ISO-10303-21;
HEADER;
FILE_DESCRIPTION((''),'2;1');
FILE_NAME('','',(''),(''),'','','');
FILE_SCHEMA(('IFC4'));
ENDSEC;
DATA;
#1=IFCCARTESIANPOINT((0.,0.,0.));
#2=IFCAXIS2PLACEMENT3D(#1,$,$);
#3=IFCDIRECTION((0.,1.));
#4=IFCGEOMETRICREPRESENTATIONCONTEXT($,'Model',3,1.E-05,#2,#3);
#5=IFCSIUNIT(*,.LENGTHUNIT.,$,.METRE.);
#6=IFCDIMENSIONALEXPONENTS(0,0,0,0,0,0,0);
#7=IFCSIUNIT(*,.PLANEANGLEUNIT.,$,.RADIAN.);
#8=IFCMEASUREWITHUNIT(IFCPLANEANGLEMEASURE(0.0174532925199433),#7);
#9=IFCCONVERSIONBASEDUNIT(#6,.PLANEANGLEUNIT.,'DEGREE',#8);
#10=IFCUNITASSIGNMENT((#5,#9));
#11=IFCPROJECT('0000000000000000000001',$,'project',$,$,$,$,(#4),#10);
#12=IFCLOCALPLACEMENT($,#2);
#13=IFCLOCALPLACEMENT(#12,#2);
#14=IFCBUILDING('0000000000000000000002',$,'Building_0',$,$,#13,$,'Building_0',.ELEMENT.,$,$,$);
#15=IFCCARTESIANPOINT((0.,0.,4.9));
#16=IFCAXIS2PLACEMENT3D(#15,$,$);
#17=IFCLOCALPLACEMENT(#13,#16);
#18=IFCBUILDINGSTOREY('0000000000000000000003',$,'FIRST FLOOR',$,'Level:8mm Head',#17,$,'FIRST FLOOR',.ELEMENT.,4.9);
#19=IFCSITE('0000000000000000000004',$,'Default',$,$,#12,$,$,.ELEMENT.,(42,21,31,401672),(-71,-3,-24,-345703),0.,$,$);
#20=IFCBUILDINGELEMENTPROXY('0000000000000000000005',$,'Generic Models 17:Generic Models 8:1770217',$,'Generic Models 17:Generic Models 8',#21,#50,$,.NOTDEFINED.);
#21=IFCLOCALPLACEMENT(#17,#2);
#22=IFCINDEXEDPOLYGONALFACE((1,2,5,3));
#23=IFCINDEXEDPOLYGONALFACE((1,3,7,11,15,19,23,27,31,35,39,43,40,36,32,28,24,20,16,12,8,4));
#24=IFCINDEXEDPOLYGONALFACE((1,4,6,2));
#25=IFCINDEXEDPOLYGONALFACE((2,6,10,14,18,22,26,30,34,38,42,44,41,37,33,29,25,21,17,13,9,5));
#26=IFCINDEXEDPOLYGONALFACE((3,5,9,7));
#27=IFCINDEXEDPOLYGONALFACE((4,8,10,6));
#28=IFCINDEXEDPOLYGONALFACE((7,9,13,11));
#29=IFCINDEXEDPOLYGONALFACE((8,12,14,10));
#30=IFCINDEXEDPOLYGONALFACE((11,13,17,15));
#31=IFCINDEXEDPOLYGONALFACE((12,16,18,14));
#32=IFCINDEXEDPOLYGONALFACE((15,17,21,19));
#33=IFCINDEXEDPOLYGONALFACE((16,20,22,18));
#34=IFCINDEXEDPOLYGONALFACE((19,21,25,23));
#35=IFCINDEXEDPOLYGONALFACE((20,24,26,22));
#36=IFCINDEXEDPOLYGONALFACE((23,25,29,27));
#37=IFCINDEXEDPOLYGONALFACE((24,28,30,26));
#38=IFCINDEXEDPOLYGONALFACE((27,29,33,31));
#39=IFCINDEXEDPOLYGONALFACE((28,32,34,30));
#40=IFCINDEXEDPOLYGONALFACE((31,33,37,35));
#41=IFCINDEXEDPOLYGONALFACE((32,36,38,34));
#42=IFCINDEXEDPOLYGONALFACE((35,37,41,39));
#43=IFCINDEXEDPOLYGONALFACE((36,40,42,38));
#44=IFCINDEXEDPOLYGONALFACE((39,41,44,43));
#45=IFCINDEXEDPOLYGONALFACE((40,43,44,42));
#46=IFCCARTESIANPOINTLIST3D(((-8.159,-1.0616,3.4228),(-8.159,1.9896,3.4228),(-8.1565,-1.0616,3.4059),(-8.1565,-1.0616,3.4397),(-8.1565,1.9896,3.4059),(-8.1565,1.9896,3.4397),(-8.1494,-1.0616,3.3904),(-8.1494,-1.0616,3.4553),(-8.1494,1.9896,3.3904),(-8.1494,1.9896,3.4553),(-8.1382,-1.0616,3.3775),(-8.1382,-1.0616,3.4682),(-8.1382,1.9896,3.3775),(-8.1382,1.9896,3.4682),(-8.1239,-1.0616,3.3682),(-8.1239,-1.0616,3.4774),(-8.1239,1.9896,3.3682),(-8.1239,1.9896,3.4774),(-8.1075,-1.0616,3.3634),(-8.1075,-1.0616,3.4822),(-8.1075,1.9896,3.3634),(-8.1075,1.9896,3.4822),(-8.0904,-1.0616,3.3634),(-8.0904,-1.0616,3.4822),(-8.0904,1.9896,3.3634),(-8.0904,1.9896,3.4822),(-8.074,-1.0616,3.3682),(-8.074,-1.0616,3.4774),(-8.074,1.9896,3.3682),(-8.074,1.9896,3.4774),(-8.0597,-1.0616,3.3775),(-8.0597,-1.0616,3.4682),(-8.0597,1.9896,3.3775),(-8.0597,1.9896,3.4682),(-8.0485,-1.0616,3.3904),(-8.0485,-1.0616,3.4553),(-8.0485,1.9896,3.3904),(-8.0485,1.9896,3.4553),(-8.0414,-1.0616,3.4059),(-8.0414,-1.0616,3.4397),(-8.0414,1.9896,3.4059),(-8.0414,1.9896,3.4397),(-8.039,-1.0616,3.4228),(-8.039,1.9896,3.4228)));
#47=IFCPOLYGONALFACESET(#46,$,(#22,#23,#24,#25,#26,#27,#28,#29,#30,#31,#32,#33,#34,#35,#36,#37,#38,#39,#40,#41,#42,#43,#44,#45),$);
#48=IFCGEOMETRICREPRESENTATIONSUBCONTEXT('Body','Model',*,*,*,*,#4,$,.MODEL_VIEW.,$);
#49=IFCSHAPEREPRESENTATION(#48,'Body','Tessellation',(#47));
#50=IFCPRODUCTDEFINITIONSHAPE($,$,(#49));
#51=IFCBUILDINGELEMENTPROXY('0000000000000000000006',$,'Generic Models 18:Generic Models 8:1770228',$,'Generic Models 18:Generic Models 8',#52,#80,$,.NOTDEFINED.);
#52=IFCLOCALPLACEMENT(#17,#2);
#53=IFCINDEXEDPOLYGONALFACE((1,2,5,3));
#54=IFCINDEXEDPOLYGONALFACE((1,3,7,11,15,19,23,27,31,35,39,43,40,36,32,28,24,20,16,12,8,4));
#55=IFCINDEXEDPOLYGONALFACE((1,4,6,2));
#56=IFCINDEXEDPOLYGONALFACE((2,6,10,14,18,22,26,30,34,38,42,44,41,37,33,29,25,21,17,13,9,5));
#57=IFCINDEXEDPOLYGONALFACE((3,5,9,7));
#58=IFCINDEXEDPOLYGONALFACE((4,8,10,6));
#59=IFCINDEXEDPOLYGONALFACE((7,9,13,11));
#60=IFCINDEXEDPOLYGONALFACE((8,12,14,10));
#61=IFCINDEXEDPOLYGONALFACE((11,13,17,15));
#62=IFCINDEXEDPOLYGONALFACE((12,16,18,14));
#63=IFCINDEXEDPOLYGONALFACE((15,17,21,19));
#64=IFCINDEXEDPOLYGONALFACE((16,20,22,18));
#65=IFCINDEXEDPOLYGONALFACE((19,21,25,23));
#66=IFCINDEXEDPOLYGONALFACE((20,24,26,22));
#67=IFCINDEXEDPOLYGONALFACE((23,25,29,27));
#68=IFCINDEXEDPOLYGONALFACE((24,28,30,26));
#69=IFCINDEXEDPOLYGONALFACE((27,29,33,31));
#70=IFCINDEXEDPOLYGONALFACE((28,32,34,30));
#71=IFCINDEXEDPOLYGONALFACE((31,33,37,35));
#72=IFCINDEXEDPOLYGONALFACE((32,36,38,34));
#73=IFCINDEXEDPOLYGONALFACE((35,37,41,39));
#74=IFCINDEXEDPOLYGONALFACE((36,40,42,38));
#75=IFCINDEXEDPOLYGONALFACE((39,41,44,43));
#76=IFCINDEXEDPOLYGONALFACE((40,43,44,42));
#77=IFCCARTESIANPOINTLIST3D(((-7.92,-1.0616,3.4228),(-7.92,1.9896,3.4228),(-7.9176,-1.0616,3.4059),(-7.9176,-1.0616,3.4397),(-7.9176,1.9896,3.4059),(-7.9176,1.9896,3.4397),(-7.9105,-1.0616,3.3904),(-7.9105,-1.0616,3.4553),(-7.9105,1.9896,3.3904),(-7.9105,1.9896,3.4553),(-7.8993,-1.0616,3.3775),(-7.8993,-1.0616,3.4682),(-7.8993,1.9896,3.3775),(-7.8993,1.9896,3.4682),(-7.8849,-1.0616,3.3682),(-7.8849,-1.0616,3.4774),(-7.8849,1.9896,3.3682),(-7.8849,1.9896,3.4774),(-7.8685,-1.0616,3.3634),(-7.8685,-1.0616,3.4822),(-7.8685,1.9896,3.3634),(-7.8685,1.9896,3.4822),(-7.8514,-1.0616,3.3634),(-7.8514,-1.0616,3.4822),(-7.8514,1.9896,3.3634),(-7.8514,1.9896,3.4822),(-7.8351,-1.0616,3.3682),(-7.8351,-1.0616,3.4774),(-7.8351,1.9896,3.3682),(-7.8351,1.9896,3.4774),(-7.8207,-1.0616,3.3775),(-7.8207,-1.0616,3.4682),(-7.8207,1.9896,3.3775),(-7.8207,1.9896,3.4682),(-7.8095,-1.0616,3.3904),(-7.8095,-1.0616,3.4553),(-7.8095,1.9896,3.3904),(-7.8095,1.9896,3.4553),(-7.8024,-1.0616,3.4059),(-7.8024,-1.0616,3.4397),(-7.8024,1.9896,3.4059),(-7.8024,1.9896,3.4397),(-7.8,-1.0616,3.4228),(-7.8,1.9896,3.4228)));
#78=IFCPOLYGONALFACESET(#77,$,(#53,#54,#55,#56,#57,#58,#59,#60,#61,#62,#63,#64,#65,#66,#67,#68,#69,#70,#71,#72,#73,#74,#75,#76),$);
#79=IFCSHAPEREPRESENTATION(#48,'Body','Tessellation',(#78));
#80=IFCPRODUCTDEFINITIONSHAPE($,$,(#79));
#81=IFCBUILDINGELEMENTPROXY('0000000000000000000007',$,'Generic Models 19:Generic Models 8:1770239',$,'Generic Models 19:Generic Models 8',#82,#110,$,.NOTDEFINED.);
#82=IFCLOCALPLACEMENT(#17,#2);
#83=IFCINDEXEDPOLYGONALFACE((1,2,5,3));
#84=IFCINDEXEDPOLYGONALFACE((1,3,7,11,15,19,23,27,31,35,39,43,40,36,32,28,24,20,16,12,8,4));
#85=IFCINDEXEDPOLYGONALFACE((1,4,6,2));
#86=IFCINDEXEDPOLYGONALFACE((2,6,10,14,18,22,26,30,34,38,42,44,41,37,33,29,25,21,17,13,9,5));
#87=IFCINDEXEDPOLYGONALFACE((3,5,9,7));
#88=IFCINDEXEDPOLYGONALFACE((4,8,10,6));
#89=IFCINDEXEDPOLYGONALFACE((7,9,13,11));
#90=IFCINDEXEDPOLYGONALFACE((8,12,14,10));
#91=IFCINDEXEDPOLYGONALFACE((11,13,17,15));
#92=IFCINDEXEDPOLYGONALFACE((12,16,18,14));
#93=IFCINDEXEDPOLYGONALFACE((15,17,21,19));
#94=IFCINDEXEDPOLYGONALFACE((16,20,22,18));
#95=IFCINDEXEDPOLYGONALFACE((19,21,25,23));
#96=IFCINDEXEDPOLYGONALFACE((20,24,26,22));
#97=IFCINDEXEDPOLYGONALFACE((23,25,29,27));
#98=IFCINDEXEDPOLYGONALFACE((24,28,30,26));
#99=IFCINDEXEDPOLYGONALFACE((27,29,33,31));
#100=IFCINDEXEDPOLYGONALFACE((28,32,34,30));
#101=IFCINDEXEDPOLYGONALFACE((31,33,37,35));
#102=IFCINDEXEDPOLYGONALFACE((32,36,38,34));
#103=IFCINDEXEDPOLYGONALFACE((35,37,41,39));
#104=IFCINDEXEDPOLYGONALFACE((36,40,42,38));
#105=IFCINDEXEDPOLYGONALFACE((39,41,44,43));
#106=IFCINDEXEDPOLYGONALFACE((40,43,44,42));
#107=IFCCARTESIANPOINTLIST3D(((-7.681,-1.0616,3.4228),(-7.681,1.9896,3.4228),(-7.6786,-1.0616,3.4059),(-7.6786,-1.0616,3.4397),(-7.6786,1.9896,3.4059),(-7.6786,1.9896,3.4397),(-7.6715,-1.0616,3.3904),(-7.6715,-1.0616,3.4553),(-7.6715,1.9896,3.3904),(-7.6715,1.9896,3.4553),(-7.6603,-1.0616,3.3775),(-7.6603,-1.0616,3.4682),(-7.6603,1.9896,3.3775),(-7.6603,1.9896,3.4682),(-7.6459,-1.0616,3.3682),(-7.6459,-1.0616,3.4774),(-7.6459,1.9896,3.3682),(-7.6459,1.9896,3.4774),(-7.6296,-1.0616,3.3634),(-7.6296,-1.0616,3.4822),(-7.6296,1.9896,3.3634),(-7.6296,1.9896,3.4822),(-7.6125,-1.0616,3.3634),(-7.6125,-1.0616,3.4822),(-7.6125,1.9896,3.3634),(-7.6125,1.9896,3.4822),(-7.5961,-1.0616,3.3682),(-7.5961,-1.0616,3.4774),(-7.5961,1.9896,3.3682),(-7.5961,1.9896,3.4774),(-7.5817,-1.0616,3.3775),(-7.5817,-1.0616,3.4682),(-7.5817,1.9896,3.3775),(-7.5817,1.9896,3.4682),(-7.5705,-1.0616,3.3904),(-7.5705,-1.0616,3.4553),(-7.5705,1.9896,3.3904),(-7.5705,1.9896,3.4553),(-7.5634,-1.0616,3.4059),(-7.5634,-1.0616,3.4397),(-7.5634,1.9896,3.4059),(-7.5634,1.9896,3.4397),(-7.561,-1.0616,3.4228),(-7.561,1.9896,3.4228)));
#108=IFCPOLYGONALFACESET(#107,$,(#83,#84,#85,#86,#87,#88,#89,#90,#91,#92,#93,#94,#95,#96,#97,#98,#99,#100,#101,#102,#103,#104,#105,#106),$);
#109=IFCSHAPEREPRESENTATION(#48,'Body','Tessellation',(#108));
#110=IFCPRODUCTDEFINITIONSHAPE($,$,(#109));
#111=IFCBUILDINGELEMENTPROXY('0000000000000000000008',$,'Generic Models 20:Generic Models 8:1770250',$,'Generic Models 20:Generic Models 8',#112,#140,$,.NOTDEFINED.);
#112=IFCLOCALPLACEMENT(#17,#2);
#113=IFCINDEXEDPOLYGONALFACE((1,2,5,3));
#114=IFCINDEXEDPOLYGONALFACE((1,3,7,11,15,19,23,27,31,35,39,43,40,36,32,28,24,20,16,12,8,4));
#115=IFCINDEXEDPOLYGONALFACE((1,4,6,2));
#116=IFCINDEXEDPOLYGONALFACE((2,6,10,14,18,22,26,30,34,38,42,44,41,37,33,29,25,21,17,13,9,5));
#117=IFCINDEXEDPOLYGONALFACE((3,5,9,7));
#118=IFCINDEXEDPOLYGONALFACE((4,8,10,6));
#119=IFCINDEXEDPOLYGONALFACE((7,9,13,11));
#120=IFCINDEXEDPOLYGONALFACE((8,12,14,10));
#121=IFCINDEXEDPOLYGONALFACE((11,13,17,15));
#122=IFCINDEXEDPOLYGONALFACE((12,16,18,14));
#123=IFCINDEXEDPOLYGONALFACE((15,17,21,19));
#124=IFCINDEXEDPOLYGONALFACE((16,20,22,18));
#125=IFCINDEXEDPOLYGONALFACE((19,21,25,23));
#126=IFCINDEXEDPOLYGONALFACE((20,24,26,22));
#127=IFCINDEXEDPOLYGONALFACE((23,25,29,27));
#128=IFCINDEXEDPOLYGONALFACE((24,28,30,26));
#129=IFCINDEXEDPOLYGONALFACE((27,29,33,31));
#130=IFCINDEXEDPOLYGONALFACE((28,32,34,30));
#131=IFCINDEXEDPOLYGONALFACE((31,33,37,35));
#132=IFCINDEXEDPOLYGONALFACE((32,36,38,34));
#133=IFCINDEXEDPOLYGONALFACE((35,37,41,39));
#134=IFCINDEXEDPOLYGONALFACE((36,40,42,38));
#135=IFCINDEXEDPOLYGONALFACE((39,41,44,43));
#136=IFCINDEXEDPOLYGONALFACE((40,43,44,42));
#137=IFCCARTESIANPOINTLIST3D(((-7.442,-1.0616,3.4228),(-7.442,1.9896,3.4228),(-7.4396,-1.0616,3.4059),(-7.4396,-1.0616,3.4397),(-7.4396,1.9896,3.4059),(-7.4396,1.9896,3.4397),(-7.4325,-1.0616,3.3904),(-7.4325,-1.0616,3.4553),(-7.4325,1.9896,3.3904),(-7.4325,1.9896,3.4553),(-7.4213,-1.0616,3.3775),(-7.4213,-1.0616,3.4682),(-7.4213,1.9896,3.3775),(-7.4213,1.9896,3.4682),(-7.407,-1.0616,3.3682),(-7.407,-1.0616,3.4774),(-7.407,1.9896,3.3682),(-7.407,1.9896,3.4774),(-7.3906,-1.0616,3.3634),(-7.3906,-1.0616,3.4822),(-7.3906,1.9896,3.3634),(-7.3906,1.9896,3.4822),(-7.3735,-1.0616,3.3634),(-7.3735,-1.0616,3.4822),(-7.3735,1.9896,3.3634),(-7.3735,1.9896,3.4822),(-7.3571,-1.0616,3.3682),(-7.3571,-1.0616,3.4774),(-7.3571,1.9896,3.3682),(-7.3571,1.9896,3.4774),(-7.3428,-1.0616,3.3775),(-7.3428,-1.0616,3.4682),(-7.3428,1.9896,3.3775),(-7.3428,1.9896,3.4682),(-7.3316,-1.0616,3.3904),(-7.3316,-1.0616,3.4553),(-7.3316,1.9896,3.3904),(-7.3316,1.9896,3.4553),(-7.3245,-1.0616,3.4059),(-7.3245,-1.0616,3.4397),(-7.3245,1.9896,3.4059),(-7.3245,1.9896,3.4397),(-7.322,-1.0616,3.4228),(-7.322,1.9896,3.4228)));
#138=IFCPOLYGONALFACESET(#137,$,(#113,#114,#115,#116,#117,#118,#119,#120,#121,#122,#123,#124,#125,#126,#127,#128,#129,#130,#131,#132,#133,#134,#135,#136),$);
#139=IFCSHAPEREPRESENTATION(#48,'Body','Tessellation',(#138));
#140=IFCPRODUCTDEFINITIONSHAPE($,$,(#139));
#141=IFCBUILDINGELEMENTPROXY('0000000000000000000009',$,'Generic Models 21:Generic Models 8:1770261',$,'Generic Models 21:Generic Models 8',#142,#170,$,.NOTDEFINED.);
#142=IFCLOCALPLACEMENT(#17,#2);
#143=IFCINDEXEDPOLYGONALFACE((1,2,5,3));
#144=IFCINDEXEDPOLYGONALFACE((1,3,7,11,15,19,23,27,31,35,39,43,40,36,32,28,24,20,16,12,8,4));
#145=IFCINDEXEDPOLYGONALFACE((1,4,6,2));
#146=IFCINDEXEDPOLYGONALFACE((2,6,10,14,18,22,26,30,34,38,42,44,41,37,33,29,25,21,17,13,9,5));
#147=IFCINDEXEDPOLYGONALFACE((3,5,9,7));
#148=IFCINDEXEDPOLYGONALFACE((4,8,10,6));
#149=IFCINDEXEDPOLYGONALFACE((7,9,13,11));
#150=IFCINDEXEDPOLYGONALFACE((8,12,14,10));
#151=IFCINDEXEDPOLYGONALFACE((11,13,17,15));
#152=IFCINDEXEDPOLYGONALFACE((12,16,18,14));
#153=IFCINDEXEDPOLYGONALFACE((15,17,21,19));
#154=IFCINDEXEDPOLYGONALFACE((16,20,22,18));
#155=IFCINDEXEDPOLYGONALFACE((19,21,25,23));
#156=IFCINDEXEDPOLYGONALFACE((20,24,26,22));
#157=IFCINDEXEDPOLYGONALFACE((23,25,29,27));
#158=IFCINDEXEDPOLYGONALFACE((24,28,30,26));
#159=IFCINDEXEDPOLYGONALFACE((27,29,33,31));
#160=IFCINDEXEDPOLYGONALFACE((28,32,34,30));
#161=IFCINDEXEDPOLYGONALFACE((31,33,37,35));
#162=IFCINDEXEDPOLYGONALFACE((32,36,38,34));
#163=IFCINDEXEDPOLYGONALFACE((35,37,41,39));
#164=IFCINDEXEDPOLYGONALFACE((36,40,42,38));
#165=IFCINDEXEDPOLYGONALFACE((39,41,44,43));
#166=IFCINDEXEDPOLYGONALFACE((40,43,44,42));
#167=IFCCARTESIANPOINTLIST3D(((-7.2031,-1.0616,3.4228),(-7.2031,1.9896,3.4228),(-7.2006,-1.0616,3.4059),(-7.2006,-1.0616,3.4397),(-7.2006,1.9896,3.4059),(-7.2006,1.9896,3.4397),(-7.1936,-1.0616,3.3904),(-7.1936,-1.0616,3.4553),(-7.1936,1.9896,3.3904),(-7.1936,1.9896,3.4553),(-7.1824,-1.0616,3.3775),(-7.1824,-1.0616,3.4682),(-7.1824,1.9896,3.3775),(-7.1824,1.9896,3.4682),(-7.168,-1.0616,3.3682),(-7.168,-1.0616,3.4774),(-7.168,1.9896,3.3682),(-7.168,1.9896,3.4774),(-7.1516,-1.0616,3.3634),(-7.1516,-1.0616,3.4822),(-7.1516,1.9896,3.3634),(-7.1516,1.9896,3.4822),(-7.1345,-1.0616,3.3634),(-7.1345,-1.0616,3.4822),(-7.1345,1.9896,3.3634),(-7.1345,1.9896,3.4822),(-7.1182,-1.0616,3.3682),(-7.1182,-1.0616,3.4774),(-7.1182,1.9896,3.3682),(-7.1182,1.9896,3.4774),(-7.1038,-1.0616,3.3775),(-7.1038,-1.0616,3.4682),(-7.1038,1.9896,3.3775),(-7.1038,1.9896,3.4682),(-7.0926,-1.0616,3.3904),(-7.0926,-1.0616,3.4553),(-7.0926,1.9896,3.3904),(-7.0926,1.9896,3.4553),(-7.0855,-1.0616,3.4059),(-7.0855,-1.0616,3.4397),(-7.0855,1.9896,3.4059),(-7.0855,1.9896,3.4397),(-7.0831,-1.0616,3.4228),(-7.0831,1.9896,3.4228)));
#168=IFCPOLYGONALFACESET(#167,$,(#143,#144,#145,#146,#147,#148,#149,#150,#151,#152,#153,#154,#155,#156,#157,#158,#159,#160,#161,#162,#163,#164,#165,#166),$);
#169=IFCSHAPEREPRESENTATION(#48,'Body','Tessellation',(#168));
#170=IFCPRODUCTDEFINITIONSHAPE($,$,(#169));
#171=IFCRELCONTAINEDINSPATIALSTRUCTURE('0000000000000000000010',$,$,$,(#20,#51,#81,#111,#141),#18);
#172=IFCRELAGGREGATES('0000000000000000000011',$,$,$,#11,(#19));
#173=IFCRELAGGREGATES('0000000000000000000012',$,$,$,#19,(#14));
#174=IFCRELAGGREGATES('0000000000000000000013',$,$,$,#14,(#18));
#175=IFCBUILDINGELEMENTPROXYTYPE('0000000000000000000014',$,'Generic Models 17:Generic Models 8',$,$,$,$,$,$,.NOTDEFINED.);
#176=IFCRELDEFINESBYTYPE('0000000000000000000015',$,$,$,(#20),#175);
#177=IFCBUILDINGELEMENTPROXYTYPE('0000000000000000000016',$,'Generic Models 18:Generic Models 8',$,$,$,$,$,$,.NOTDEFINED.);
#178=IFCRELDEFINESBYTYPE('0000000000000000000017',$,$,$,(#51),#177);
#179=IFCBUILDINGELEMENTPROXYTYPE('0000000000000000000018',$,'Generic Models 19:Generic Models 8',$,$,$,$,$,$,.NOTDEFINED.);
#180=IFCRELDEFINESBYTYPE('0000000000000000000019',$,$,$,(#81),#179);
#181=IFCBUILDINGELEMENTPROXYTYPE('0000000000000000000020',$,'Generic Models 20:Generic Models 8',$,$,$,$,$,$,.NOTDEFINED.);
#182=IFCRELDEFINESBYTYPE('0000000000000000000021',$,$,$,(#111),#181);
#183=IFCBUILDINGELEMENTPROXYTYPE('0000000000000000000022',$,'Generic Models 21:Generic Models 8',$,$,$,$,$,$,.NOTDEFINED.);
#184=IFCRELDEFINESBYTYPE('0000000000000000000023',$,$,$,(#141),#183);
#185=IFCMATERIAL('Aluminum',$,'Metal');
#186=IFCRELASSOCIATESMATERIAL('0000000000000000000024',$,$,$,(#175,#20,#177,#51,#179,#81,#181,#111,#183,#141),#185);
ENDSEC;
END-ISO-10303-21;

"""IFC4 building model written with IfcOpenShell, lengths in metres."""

from ifc_helpers import new_model, entity, si_unit, converted_unit, direction, frame, origin, place, context, subcontext, project, spatial, arc, indexed_curve, outline, extrude, source, transform, mapped, material, type_object, type_shapes, element, save


model = new_model("IFC4")

# Units and contexts
model_context = context("Model", 3, precision=1e-05, world=origin(), true_north=direction((0.0, 1.0)))
body_context = subcontext(model_context, "Body", "Model", "MODEL_VIEW")
ifc_project = project(units=[si_unit("LENGTHUNIT", "METRE"), converted_unit("PLANEANGLEUNIT", "DEGREE", entity("IfcPlaneAngleMeasure", 0.0174532925199433), si_unit("PLANEANGLEUNIT", "RADIAN"), dimensions=[0, 0, 0, 0, 0, 0, 0])], contexts=[model_context])

# Site, building, storey
site_placement = place(None, origin())
site = spatial("IfcSite", under=ifc_project, at=site_placement, Name="Default", CompositionType="ELEMENT", RefLatitude=(42, 21, 31, 401672), RefLongitude=(-71, -3, -24, -345703), RefElevation=0.0)
building_placement = place(site_placement, origin())
building = spatial("IfcBuilding", under=site, at=building_placement, Name="Building_0", LongName="Building_0", CompositionType="ELEMENT")
storey_placement = place(building_placement, frame((0.0, 0.0, 4.9)))
storey = spatial("IfcBuildingStorey", under=building, at=storey_placement, Name="FIRST FLOOR", ObjectType="Level:8mm Head", LongName="FIRST FLOOR", CompositionType="ELEMENT", Elevation=4.9)

# Building element proxies
ifc_material = material(Name="Aluminum", Category="Metal")
building_element_proxy_type_1 = type_object("IfcBuildingElementProxyType", Name="Generic Models 17:Generic Models 8", PredefinedType="NOTDEFINED", material=ifc_material)
shared_shape_1 = source(origin(), body_context, "Body", "SweptSolid", [
    extrude(outline(indexed_curve([(-0.06, 0.0), (0.0, -0.06), (0.06, 0.0), (0.0, 0.06)], segments=[arc(1, 2, 3), arc(3, 4, 1)], self_intersect=False)), frame((-8.099, -1.0616, 8.3228), z_axis=(0.0, 1.0, 0.0), x_axis=(-1.0, 0.0, 0.0)), (0.0, 0.0, 1.0), 3.0512),
])
type_shapes(building_element_proxy_type_1, [shared_shape_1])
proxy_1_placement = place(storey_placement, frame((0.0, 0.0, -4.9)))
element("IfcBuildingElementProxy", 1, at=proxy_1_placement, inside=storey, type_object=building_element_proxy_type_1, material=ifc_material, Name="Generic Models 17:Generic Models 8:1770217", ObjectType="Generic Models 17:Generic Models 8", PredefinedType="NOTDEFINED", context=body_context, shape_type="MappedRepresentation", body=[
    mapped(shared_shape_1, transform((0.0, 0.0, 0.0), scale=1.0)),
])
building_element_proxy_type_2 = type_object("IfcBuildingElementProxyType", Name="Generic Models 18:Generic Models 8", PredefinedType="NOTDEFINED", material=ifc_material)
shared_shape_2 = source(origin(), body_context, "Body", "SweptSolid", [
    extrude(outline(indexed_curve([(-0.06, 0.0), (0.0, -0.06), (0.06, 0.0), (0.0, 0.06)], segments=[arc(1, 2, 3), arc(3, 4, 1)], self_intersect=False)), frame((-7.86, -1.0616, 8.3228), z_axis=(0.0, 1.0, 0.0), x_axis=(-1.0, 0.0, 0.0)), (0.0, 0.0, 1.0), 3.0512),
])
type_shapes(building_element_proxy_type_2, [shared_shape_2])
proxy_2_placement = place(storey_placement, frame((0.0, 0.0, -4.9)))
element("IfcBuildingElementProxy", 2, at=proxy_2_placement, inside=storey, type_object=building_element_proxy_type_2, material=ifc_material, Name="Generic Models 18:Generic Models 8:1770228", ObjectType="Generic Models 18:Generic Models 8", PredefinedType="NOTDEFINED", context=body_context, shape_type="MappedRepresentation", body=[
    mapped(shared_shape_2, transform((0.0, 0.0, 0.0), scale=1.0)),
])
building_element_proxy_type_3 = type_object("IfcBuildingElementProxyType", Name="Generic Models 19:Generic Models 8", PredefinedType="NOTDEFINED", material=ifc_material)
shared_shape_3 = source(origin(), body_context, "Body", "SweptSolid", [
    extrude(outline(indexed_curve([(-0.06, 0.0), (0.0, -0.06), (0.06, 0.0), (0.0, 0.06)], segments=[arc(1, 2, 3), arc(3, 4, 1)], self_intersect=False)), frame((-7.621, -1.0616, 8.3228), z_axis=(0.0, 1.0, 0.0), x_axis=(-1.0, 0.0, 0.0)), (0.0, 0.0, 1.0), 3.0512),
])
type_shapes(building_element_proxy_type_3, [shared_shape_3])
proxy_3_placement = place(storey_placement, frame((0.0, 0.0, -4.9)))
element("IfcBuildingElementProxy", 3, at=proxy_3_placement, inside=storey, type_object=building_element_proxy_type_3, material=ifc_material, Name="Generic Models 19:Generic Models 8:1770239", ObjectType="Generic Models 19:Generic Models 8", PredefinedType="NOTDEFINED", context=body_context, shape_type="MappedRepresentation", body=[
    mapped(shared_shape_3, transform((0.0, 0.0, 0.0), scale=1.0)),
])
building_element_proxy_type_4 = type_object("IfcBuildingElementProxyType", Name="Generic Models 20:Generic Models 8", PredefinedType="NOTDEFINED", material=ifc_material)
shared_shape_4 = source(origin(), body_context, "Body", "SweptSolid", [
    extrude(outline(indexed_curve([(-0.06, 0.0), (0.0, -0.06), (0.06, 0.0), (0.0, 0.06)], segments=[arc(1, 2, 3), arc(3, 4, 1)], self_intersect=False)), frame((-7.382, -1.0616, 8.3228), z_axis=(0.0, 1.0, 0.0), x_axis=(-1.0, 0.0, 0.0)), (0.0, 0.0, 1.0), 3.0512),
])
type_shapes(building_element_proxy_type_4, [shared_shape_4])
proxy_4_placement = place(storey_placement, frame((0.0, 0.0, -4.9)))
element("IfcBuildingElementProxy", 4, at=proxy_4_placement, inside=storey, type_object=building_element_proxy_type_4, material=ifc_material, Name="Generic Models 20:Generic Models 8:1770250", ObjectType="Generic Models 20:Generic Models 8", PredefinedType="NOTDEFINED", context=body_context, shape_type="MappedRepresentation", body=[
    mapped(shared_shape_4, transform((0.0, 0.0, 0.0), scale=1.0)),
])
building_element_proxy_type_5 = type_object("IfcBuildingElementProxyType", Name="Generic Models 21:Generic Models 8", PredefinedType="NOTDEFINED", material=ifc_material)
shared_shape_5 = source(origin(), body_context, "Body", "SweptSolid", [
    extrude(outline(indexed_curve([(-0.06, 0.0), (0.0, -0.06), (0.06, 0.0), (0.0, 0.06)], segments=[arc(1, 2, 3), arc(3, 4, 1)], self_intersect=False)), frame((-7.1431, -1.0616, 8.3228), z_axis=(0.0, 1.0, 0.0), x_axis=(-1.0, 0.0, 0.0)), (0.0, 0.0, 1.0), 3.0512),
])
type_shapes(building_element_proxy_type_5, [shared_shape_5])
proxy_5_placement = place(storey_placement, frame((0.0, 0.0, -4.9)))
element("IfcBuildingElementProxy", 5, at=proxy_5_placement, inside=storey, type_object=building_element_proxy_type_5, material=ifc_material, Name="Generic Models 21:Generic Models 8:1770261", ObjectType="Generic Models 21:Generic Models 8", PredefinedType="NOTDEFINED", context=body_context, shape_type="MappedRepresentation", body=[
    mapped(shared_shape_5, transform((0.0, 0.0, 0.0), scale=1.0)),
])

save(model, "model.ifc")
